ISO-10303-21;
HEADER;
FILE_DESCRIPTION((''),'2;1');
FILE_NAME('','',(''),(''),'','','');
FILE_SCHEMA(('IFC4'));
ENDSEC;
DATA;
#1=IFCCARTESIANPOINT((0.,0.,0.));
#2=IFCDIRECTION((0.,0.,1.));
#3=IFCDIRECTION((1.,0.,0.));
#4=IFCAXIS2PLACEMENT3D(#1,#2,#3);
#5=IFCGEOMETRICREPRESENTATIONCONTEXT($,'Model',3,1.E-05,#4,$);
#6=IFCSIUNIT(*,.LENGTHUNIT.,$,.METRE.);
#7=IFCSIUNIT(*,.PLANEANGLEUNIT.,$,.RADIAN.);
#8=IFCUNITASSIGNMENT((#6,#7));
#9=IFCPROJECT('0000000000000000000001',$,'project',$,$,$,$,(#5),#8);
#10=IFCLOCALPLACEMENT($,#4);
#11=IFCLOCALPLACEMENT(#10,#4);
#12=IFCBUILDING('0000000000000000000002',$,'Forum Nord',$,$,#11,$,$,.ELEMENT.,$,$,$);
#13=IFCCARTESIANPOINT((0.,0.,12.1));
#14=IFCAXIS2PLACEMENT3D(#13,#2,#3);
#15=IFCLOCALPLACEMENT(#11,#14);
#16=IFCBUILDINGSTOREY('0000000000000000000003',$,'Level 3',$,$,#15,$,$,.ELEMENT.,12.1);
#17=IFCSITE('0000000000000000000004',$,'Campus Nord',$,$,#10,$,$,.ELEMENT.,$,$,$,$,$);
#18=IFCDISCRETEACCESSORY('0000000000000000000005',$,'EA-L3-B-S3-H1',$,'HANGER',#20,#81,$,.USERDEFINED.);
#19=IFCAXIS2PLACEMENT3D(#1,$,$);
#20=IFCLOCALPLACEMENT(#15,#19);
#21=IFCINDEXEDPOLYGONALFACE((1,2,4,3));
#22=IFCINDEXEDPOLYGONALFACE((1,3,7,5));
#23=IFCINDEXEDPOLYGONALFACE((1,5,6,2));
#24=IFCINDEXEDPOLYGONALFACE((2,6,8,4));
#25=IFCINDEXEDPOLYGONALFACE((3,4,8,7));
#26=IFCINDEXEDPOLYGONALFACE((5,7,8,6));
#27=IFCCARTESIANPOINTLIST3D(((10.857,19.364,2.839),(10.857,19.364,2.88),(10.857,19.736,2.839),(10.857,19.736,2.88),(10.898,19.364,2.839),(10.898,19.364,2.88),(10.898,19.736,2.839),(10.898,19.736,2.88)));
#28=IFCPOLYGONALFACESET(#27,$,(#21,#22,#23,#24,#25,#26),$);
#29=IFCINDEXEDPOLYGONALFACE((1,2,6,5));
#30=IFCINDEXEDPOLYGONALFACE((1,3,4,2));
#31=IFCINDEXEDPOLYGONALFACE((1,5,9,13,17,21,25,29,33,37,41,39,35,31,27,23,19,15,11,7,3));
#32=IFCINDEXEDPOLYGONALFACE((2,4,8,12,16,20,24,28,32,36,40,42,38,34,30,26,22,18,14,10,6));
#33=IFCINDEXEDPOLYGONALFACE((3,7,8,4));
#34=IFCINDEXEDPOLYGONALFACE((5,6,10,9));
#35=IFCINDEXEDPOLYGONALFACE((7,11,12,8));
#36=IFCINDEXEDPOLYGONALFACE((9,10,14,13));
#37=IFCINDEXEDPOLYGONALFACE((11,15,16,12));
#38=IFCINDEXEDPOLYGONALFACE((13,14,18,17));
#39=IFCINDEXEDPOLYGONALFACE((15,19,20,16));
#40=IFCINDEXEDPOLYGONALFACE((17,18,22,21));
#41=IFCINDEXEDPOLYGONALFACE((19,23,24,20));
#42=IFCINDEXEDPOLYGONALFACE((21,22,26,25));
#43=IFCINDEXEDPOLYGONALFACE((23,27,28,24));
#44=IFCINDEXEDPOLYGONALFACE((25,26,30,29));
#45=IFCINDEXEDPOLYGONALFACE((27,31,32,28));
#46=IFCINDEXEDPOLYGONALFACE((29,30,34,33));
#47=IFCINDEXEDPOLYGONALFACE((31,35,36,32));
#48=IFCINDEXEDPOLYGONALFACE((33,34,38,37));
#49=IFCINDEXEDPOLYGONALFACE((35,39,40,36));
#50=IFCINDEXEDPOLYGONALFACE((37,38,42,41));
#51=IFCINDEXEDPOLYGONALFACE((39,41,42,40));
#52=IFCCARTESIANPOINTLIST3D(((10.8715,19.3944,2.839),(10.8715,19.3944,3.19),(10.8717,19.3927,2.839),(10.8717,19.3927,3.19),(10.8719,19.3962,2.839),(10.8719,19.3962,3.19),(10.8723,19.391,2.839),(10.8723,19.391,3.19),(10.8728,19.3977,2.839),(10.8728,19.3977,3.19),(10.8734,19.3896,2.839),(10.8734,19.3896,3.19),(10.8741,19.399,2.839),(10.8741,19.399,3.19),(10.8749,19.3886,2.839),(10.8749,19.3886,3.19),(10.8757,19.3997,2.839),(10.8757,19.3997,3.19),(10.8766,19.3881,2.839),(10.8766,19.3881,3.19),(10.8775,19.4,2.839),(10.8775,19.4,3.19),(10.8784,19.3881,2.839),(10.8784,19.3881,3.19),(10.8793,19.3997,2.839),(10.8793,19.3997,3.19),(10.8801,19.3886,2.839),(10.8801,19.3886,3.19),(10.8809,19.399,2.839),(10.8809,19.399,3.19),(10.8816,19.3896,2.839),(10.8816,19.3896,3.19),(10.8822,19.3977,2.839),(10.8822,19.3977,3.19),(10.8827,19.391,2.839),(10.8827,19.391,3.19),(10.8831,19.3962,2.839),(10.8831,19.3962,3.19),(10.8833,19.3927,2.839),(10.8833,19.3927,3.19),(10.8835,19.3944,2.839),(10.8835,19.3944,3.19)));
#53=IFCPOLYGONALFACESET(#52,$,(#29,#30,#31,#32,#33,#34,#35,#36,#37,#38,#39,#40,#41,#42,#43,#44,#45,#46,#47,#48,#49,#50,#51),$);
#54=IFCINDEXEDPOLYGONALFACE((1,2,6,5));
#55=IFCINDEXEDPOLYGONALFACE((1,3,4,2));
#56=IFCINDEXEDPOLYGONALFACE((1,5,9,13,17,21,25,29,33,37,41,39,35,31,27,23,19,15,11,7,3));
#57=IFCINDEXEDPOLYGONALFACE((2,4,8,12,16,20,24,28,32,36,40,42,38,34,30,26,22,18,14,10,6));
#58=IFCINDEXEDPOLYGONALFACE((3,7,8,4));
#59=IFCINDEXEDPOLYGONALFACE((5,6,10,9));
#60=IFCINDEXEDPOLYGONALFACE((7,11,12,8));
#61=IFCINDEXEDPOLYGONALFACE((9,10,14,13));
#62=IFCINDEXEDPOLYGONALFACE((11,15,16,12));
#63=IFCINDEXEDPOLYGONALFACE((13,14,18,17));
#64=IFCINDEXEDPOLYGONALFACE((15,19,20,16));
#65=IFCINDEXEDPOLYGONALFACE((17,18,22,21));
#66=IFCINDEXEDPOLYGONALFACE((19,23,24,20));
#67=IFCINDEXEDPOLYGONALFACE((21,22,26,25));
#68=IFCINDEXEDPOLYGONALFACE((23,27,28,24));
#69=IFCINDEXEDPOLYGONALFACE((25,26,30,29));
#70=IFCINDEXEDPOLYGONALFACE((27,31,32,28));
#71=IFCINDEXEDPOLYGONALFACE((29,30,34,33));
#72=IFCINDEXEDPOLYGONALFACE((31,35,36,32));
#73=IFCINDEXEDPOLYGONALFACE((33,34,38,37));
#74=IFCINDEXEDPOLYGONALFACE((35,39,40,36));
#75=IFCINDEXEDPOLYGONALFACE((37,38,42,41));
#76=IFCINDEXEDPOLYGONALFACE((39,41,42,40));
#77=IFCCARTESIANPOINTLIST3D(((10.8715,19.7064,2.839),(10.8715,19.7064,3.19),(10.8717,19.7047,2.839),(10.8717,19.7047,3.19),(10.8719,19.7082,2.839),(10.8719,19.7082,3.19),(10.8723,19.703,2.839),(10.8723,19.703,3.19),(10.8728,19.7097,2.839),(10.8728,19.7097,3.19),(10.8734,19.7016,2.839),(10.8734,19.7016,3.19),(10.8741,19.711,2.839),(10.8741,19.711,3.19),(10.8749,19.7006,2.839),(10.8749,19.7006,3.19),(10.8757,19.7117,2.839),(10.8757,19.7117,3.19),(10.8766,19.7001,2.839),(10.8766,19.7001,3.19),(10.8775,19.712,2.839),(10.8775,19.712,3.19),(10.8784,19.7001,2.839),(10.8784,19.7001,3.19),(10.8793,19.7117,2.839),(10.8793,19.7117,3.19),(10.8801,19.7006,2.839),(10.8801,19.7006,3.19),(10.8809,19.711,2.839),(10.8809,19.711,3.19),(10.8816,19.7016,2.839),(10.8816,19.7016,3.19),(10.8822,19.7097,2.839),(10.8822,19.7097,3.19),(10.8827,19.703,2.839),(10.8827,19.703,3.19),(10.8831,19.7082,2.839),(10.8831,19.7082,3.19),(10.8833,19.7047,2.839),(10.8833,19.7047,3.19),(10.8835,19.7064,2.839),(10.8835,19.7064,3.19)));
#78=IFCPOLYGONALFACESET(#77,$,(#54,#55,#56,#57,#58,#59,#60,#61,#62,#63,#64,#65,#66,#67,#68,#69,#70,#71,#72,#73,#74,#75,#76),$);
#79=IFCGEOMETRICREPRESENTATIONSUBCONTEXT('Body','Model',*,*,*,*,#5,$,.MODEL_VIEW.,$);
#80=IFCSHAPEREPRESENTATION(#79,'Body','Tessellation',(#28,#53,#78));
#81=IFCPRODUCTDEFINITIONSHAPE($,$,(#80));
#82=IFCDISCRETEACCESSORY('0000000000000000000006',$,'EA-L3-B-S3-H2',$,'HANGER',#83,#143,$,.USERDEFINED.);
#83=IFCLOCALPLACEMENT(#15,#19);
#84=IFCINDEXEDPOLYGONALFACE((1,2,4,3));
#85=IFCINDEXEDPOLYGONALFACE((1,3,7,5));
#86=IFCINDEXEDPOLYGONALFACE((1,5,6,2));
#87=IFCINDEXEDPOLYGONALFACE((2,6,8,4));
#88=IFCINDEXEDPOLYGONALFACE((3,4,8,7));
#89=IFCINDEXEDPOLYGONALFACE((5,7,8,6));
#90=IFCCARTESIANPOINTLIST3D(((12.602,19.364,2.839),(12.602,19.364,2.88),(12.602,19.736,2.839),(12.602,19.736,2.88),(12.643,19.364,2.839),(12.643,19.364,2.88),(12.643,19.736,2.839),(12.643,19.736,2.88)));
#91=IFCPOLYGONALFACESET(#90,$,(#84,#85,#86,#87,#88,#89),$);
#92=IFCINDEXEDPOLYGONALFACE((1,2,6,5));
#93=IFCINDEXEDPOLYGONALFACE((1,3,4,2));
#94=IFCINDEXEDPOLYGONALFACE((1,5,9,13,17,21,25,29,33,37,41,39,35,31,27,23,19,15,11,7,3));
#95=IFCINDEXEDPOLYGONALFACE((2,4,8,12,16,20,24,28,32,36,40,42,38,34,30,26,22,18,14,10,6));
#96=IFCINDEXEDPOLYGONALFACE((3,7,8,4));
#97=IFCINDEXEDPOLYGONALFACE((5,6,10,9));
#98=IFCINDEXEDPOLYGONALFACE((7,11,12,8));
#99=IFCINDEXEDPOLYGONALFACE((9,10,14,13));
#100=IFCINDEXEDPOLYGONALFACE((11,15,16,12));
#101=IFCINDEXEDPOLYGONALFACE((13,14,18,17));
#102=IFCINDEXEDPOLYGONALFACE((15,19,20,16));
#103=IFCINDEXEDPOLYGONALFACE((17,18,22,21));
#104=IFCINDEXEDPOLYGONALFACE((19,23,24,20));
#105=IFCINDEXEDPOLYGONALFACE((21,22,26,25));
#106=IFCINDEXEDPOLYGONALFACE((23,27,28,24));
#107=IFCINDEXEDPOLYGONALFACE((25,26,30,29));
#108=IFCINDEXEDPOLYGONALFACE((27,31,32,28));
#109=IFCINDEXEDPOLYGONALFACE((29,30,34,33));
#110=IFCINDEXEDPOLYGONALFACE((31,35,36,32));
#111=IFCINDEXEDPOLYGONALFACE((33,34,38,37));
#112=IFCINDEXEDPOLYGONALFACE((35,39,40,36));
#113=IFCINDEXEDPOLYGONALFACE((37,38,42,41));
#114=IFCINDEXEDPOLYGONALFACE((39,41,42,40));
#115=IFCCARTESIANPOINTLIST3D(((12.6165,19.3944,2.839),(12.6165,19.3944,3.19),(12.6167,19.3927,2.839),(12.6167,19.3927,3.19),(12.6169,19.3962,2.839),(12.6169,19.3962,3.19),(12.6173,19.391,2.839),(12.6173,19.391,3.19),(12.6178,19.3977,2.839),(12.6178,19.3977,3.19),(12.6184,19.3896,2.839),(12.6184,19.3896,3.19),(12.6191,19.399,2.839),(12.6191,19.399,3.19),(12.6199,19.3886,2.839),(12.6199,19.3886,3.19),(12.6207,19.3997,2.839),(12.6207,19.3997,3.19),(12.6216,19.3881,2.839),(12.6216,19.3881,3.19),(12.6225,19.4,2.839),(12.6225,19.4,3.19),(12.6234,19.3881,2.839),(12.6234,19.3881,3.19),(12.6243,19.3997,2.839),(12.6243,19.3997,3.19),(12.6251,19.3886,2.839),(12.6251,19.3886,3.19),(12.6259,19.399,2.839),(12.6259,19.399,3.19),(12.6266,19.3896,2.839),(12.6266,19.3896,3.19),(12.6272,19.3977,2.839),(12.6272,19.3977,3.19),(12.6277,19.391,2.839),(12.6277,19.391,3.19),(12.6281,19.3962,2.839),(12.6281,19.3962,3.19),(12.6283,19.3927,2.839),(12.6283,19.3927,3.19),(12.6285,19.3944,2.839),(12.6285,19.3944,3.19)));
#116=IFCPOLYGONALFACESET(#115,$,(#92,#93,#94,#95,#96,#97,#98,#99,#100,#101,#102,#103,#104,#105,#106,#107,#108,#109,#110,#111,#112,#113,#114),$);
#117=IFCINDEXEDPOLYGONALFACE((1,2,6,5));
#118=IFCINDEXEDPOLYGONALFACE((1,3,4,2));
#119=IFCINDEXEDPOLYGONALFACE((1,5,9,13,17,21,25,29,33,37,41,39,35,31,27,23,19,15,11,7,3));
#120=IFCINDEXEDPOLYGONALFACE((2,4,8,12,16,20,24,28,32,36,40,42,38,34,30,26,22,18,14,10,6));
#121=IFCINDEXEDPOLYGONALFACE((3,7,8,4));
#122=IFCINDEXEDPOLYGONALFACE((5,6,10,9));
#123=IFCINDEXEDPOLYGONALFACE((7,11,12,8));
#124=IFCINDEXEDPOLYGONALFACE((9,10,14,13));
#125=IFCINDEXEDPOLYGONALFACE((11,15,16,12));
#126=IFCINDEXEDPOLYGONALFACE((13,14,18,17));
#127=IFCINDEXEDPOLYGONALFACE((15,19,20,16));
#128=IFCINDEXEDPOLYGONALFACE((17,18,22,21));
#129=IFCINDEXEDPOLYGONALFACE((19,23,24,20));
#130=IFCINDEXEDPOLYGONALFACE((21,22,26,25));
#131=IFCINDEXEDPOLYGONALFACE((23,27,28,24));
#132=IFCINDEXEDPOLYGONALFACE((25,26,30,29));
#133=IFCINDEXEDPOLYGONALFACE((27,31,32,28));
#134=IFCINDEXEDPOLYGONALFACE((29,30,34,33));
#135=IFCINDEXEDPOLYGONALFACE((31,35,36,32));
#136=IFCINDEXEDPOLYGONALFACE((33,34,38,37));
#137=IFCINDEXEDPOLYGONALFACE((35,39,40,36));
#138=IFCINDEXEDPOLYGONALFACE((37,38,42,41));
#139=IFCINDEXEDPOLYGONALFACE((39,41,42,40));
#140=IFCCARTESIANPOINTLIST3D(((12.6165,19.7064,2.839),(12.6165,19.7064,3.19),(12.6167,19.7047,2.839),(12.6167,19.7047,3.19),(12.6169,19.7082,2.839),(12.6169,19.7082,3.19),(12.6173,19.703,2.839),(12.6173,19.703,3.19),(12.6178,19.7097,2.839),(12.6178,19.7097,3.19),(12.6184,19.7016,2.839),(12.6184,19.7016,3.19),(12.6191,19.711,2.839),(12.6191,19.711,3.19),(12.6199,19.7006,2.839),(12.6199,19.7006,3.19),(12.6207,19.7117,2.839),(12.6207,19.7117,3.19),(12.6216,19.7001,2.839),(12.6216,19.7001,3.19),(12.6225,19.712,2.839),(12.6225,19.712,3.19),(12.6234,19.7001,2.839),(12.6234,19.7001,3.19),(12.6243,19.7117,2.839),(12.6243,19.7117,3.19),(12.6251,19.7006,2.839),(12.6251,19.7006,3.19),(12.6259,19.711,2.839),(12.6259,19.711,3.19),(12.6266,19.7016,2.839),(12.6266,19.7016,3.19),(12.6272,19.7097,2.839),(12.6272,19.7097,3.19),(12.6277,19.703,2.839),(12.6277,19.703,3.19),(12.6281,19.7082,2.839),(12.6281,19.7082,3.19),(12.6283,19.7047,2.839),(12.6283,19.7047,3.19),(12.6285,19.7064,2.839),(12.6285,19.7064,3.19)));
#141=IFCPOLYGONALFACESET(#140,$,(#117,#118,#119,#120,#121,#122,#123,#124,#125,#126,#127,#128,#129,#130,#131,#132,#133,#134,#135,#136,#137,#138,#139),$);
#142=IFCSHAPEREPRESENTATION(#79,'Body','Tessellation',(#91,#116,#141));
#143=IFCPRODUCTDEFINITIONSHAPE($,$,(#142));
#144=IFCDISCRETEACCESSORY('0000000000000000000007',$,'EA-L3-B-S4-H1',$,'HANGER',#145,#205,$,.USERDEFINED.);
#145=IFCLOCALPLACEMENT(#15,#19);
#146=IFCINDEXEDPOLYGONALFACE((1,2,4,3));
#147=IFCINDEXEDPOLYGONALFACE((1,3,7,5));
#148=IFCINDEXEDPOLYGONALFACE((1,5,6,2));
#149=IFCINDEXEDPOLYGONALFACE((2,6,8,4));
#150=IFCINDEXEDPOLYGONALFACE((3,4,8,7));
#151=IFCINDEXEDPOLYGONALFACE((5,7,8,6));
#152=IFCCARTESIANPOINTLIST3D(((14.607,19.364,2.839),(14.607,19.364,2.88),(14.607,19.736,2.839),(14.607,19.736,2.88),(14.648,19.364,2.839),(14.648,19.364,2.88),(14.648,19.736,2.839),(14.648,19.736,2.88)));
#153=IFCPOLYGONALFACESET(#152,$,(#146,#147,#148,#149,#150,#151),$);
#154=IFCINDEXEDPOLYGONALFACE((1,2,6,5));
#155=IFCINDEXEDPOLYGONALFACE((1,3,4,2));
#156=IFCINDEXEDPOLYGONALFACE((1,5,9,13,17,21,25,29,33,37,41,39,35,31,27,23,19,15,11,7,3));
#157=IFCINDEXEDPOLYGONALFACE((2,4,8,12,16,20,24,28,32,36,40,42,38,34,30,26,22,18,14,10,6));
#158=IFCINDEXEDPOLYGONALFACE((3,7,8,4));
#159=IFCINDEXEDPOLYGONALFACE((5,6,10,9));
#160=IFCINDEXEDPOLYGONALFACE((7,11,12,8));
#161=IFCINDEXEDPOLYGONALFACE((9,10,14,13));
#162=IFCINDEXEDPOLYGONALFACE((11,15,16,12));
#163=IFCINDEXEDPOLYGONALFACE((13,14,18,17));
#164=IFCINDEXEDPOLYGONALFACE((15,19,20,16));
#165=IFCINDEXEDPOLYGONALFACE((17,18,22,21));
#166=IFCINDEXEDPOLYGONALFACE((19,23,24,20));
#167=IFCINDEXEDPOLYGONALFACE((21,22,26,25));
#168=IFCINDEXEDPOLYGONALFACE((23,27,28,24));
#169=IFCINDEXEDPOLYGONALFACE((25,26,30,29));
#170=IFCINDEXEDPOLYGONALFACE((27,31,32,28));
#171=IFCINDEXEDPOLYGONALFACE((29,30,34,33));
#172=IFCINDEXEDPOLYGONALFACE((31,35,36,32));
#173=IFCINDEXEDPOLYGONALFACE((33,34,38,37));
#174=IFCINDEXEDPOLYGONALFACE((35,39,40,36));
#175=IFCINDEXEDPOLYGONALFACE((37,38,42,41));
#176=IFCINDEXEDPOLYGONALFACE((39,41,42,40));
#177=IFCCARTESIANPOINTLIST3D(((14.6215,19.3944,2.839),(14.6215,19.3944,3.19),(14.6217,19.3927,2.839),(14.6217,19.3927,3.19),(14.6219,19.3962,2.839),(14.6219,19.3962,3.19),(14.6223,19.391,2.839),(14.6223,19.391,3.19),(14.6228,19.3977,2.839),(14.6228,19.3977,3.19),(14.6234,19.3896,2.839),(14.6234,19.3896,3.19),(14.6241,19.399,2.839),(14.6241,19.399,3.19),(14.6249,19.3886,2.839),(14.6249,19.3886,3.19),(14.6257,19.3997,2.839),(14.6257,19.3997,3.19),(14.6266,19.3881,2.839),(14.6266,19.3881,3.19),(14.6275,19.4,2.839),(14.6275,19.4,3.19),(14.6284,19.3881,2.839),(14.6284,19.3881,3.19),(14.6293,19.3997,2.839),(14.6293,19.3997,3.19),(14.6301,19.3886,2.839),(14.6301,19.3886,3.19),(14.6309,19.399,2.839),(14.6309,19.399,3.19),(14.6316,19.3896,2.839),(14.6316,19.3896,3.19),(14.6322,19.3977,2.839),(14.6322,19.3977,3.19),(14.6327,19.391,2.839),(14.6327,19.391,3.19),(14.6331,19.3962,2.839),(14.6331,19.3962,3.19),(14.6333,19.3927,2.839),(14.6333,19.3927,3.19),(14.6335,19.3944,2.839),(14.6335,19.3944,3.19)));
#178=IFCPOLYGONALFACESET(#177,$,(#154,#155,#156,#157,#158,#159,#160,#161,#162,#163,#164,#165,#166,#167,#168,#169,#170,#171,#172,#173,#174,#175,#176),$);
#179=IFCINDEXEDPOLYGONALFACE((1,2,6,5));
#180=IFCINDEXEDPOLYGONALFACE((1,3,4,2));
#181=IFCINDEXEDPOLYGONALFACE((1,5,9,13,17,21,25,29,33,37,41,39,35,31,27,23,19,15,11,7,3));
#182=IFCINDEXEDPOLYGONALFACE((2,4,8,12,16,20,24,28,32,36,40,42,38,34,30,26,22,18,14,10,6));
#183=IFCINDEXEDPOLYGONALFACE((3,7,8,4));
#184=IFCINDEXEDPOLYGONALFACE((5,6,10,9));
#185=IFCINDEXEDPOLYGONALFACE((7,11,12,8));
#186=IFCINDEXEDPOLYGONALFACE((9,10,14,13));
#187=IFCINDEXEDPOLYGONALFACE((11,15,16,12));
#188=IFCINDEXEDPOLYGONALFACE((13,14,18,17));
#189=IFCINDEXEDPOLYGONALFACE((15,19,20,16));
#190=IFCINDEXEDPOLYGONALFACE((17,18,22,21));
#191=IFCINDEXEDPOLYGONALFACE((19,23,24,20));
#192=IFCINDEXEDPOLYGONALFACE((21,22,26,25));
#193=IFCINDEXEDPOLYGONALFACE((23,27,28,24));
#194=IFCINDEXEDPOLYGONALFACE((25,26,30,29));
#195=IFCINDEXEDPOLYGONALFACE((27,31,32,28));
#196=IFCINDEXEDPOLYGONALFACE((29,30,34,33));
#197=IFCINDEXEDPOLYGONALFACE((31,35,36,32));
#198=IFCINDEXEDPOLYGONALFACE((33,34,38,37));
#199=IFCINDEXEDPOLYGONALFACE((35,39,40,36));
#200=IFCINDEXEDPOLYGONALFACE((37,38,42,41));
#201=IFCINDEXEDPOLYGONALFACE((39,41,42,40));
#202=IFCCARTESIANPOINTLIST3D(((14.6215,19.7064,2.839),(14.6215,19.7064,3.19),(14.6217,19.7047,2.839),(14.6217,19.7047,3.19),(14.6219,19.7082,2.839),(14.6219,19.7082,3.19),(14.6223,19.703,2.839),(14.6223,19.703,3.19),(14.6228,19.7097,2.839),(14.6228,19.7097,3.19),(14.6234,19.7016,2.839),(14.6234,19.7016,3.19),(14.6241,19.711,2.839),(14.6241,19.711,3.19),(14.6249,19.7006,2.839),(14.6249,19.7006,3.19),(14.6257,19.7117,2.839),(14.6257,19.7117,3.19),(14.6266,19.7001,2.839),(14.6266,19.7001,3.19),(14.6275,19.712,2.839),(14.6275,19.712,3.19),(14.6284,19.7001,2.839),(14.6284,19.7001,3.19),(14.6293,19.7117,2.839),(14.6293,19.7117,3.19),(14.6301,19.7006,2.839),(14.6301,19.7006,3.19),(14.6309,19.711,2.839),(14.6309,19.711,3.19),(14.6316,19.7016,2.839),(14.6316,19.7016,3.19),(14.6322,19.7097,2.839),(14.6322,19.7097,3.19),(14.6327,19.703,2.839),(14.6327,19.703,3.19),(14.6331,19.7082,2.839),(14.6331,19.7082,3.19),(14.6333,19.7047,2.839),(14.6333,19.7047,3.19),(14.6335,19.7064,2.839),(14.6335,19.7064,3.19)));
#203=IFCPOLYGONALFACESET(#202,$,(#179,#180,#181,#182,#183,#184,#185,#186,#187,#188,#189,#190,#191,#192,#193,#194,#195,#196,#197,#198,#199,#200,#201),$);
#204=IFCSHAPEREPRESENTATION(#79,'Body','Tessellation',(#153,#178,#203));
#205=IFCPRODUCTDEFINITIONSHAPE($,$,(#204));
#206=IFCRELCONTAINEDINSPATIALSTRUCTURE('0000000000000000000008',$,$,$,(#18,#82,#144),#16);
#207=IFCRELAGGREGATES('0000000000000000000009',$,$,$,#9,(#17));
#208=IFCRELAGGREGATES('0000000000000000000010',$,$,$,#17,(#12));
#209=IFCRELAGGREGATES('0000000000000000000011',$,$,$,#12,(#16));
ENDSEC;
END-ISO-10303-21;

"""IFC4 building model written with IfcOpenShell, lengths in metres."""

from ifc_helpers import new_model, si_unit, frame, frame_2d, origin_with_axes, origin_2d_with_axis, place, context, subcontext, project, spatial, rectangle, circle, extrude, element, save


model = new_model("IFC4")

# Units and contexts
model_context = context("Model", 3, precision=1e-05, world=origin_with_axes())
body_context = subcontext(model_context, "Body", "Model", "MODEL_VIEW")
ifc_project = project(units=[si_unit("LENGTHUNIT", "METRE"), si_unit("PLANEANGLEUNIT", "RADIAN")], contexts=[model_context])

# Site, building, storey
site_placement = place(None, origin_with_axes())
site = spatial("IfcSite", under=ifc_project, at=site_placement, Name="Campus Nord", CompositionType="ELEMENT")
building_placement = place(site_placement, origin_with_axes())
building = spatial("IfcBuilding", under=site, at=building_placement, Name="Forum Nord", CompositionType="ELEMENT")
storey_placement = place(building_placement, frame((0.0, 0.0, 12.1), z_axis=(0.0, 0.0, 1.0), x_axis=(1.0, 0.0, 0.0)))
storey = spatial("IfcBuildingStorey", under=building, at=storey_placement, Name="Level 3", CompositionType="ELEMENT", Elevation=12.1)

# Discrete accessories
for number, where, z_axis, x_axis, name in (
    (1, (10.8775, 19.55, 2.88), (0.0, 0.0, 1.0), (0.0, 1.0, 0.0), "EA-L3-B-S3-H1"),
    (2, (12.6225, 19.55, 2.88), (0.0, 0.0, 1.0), (0.0, 1.0, 0.0), "EA-L3-B-S3-H2"),
    (3, (14.6275, 19.55, 2.88), (0.0, 0.0, 1.0), (0.0, 1.0, 0.0), "EA-L3-B-S4-H1"),
):
    element("IfcDiscreteAccessory", number, at=place(storey_placement, frame(where, z_axis=z_axis, x_axis=x_axis)), inside=storey, Name=name, ObjectType="HANGER", PredefinedType="USERDEFINED", context=body_context, shape_type="SweptSolid", body=[
        extrude(rectangle(XDim=0.372, YDim=0.041, at=origin_2d_with_axis()), frame((0.0, 0.0, -0.041), z_axis=(0.0, 0.0, 1.0), x_axis=(1.0, 0.0, 0.0)), (0.0, 0.0, 1.0), 0.041),
        extrude(circle(Radius=0.006, at=frame_2d((-0.156, 0.0), x_axis=(1.0, 0.0))), frame((0.0, 0.0, -0.041), z_axis=(0.0, 0.0, 1.0), x_axis=(1.0, 0.0, 0.0)), (0.0, 0.0, 1.0), 0.351),
        extrude(circle(Radius=0.006, at=frame_2d((0.156, 0.0), x_axis=(1.0, 0.0))), frame((0.0, 0.0, -0.041), z_axis=(0.0, 0.0, 1.0), x_axis=(1.0, 0.0, 0.0)), (0.0, 0.0, 1.0), 0.351),
    ])

save(model, "model.ifc")
